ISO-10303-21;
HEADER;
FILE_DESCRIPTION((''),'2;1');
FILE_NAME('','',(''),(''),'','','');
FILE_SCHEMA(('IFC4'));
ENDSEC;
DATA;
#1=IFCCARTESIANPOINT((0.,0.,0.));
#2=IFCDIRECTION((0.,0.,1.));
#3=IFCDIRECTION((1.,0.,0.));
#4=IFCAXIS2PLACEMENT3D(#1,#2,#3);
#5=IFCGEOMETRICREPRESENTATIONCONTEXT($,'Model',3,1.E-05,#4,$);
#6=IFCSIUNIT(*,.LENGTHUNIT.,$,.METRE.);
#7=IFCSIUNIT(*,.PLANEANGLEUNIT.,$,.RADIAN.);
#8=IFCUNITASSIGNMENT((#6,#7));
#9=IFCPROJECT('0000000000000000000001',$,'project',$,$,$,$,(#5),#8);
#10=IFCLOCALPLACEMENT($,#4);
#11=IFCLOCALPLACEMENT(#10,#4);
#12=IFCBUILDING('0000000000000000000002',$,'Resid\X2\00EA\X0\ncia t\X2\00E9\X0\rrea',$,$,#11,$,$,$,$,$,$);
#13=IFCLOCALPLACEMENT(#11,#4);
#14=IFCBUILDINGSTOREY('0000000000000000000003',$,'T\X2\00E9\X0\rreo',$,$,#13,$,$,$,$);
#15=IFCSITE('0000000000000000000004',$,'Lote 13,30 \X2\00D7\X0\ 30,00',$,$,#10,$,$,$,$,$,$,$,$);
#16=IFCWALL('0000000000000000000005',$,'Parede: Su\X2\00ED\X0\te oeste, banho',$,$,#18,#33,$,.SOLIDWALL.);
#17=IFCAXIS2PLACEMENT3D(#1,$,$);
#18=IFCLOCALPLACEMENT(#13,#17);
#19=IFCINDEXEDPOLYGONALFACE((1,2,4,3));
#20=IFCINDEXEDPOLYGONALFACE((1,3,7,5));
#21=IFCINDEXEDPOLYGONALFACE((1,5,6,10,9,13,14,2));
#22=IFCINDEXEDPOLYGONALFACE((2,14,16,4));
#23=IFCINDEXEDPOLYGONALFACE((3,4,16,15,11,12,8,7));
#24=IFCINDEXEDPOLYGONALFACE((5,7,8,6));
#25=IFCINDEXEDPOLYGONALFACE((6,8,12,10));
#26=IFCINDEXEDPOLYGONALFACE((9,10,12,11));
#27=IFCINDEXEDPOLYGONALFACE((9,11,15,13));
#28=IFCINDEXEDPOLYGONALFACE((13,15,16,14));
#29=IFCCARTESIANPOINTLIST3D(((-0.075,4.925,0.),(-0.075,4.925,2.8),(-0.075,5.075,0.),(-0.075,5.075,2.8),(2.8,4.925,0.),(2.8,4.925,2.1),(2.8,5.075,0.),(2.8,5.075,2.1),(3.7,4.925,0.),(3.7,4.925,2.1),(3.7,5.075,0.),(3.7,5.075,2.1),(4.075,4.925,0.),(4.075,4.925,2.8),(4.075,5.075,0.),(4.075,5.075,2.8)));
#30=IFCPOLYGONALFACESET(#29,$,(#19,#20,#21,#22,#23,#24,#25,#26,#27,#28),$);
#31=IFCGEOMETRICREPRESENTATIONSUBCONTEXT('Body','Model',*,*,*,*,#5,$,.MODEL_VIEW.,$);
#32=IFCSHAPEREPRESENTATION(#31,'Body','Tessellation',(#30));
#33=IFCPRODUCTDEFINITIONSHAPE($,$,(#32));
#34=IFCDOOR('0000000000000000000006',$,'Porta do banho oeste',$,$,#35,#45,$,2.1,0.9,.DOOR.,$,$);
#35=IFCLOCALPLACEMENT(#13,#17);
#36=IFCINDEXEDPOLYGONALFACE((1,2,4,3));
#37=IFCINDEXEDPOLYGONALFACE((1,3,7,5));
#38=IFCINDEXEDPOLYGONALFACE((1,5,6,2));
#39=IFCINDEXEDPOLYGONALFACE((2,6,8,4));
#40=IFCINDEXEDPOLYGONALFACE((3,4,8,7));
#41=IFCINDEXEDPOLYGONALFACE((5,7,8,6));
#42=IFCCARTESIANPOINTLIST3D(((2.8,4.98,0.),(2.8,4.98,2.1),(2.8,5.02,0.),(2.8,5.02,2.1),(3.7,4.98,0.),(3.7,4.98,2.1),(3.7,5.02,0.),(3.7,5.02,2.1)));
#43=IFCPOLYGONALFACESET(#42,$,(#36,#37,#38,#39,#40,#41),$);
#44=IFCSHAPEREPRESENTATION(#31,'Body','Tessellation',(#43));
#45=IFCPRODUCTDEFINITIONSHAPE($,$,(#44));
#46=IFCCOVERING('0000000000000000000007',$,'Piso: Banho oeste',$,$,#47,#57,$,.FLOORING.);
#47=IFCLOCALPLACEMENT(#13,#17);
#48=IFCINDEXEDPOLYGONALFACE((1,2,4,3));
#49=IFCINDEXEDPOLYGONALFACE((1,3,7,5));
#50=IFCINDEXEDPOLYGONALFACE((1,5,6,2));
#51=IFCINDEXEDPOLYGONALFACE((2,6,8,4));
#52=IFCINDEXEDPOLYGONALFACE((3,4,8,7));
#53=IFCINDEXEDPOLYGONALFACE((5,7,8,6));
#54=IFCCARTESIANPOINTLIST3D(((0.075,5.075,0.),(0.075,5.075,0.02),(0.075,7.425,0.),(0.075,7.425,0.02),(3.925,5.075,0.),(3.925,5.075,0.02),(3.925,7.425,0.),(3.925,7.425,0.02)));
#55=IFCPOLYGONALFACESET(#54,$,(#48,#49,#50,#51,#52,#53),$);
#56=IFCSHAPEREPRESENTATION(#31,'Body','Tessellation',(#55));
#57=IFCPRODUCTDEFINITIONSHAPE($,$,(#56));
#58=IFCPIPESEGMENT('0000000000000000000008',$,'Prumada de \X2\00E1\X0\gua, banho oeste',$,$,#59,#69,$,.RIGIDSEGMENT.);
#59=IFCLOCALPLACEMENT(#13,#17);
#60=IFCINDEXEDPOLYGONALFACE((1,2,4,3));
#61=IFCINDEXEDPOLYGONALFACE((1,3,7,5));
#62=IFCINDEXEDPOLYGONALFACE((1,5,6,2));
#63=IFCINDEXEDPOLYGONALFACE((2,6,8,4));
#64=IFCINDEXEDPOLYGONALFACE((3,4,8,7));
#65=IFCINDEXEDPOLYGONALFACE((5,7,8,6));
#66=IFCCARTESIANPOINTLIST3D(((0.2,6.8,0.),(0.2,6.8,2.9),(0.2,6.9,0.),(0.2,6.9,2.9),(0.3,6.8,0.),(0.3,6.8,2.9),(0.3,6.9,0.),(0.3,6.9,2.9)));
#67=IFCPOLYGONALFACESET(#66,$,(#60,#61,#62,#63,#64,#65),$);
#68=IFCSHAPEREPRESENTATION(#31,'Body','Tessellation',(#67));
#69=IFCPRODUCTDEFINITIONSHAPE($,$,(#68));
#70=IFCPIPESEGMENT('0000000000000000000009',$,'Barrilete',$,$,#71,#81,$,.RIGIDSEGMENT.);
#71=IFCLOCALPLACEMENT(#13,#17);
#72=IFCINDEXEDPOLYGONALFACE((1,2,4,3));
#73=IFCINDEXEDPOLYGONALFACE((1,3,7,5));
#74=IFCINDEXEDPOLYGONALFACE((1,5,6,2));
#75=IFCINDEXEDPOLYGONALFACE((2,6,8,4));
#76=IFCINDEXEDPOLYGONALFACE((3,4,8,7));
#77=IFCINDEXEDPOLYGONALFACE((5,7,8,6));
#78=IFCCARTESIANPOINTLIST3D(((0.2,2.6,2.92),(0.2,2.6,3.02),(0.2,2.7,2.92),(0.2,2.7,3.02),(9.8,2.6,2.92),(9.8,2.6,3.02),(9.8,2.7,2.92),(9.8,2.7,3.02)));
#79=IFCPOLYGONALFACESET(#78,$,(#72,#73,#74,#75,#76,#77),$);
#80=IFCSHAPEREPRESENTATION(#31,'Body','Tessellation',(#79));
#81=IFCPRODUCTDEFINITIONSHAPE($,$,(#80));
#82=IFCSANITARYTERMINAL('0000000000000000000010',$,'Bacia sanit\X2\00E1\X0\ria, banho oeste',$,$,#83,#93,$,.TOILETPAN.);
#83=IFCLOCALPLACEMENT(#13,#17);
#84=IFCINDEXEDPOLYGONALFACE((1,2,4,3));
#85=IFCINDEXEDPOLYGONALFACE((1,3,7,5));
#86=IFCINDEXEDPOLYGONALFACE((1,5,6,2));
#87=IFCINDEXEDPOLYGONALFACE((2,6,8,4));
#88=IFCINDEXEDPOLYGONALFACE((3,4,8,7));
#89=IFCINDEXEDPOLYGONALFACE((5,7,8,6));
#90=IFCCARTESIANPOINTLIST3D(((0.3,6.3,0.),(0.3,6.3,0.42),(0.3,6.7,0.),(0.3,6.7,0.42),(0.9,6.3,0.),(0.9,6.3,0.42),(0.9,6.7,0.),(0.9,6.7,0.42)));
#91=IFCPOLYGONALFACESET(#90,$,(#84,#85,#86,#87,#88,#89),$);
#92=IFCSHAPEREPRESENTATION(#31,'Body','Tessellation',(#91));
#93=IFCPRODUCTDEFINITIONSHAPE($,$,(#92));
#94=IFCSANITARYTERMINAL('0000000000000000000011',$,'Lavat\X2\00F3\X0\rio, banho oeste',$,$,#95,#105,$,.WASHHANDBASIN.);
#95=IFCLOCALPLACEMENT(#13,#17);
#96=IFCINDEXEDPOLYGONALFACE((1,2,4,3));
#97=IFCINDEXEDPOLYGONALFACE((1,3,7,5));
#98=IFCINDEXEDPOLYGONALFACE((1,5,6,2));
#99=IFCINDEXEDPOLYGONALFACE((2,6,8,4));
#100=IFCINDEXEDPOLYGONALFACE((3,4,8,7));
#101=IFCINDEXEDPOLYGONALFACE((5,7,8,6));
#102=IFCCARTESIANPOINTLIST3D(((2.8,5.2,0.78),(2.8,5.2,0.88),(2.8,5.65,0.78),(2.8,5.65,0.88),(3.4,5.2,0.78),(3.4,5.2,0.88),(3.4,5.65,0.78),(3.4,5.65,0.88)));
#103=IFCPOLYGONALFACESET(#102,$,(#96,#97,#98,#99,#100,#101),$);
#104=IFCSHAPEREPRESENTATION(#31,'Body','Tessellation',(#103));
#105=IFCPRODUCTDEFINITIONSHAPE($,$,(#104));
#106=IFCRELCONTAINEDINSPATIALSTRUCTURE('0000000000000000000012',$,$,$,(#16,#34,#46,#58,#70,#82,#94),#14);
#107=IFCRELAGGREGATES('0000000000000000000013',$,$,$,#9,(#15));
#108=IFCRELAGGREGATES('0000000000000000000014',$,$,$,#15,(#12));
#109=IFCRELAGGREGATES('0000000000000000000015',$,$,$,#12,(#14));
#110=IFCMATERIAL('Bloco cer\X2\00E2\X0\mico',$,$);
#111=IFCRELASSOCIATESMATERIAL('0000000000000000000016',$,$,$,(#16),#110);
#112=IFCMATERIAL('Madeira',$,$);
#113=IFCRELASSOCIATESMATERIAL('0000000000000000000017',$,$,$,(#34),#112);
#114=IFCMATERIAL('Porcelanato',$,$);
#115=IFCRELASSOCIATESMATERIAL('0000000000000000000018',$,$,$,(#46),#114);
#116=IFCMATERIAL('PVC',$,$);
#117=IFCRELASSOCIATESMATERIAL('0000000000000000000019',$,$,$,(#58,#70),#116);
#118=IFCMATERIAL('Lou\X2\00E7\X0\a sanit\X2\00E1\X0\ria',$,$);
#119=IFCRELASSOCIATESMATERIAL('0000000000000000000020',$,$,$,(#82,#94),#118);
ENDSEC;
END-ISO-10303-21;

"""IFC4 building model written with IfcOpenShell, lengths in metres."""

from ifc_helpers import new_model, si_unit, frame, origin_with_axes, place, context, subcontext, project, spatial, line, indexed_curve, outline, extrude, material, element, fill, save


model = new_model("IFC4")

# Units and contexts
model_context = context("Model", 3, precision=1e-05, world=origin_with_axes())
body_context = subcontext(model_context, "Body", "Model", "MODEL_VIEW")
ifc_project = project(units=[si_unit("LENGTHUNIT", "METRE"), si_unit("PLANEANGLEUNIT", "RADIAN")], contexts=[model_context])

# Site, building, storey
site_placement = place(None, origin_with_axes())
site = spatial("IfcSite", under=ifc_project, at=site_placement, Name="Lote 13,30 × 30,00")
building_placement = place(site_placement, origin_with_axes())
building = spatial("IfcBuilding", under=site, at=building_placement, Name="Residência térrea")
storey_placement = place(building_placement, origin_with_axes())
storey = spatial("IfcBuildingStorey", under=building, at=storey_placement, Name="Térreo")

# Shared definitions
ifc_material_1 = material(Name="Concreto armado")

# Shared definitions
ifc_material_2 = material(Name="Bloco cerâmico")

# Wall, opening, door
wall_1_placement = place(storey_placement, frame((-0.075, 4.925, 0.0), z_axis=(0.0, 0.0, 1.0), x_axis=(1.0, 0.0, 0.0)))
wall_1 = element("IfcWall", 1, at=wall_1_placement, inside=storey, material=ifc_material_2, Name="Parede: Suíte oeste, banho", PredefinedType="SOLIDWALL", context=body_context, shape_type="SweptSolid", body=[
    extrude(outline(indexed_curve([(0.0, 0.0), (4.15, 0.0), (4.15, 0.15), (0.0, 0.15)], segments=[line(1, 2, 3, 4, 1)])), origin_with_axes(), (0.0, 0.0, 1.0), 2.8),
])
opening_1_placement = place(wall_1_placement, frame((2.875, -0.05, 0.0), z_axis=(0.0, 0.0, 1.0), x_axis=(1.0, 0.0, 0.0)))
opening_1 = element("IfcOpeningElement", 2, at=opening_1_placement, cuts=wall_1, material=ifc_material_1, PredefinedType="OPENING", context=body_context, shape_type="SweptSolid", body=[
    extrude(outline(indexed_curve([(0.0, 0.0), (0.9, 0.0), (0.9, 0.25), (0.0, 0.25)], segments=[line(1, 2, 3, 4, 1)])), origin_with_axes(), (0.0, 0.0, 1.0), 2.1),
])
ifc_material_3 = material(Name="Madeira")
door_placement = place(storey_placement, frame((2.8, 4.98, 0.0), z_axis=(0.0, 0.0, 1.0), x_axis=(1.0, 0.0, 0.0)))
door = element("IfcDoor", 3, at=door_placement, inside=storey, material=ifc_material_3, Name="Porta do banho oeste", OverallHeight=2.1, OverallWidth=0.9, PredefinedType="DOOR", context=body_context, shape_type="SweptSolid", body=[
    extrude(outline(indexed_curve([(0.0, 0.0), (0.9, 0.0), (0.9, 0.04), (0.0, 0.04)], segments=[line(1, 2, 3, 4, 1)])), origin_with_axes(), (0.0, 0.0, 1.0), 2.1),
])
fill(opening_1, door)

# Covering
ifc_material_4 = material(Name="Porcelanato")
covering_placement = place(storey_placement, frame((0.075, 5.075, 0.0), z_axis=(0.0, 0.0, 1.0), x_axis=(1.0, 0.0, 0.0)))
element("IfcCovering", 4, at=covering_placement, inside=storey, material=ifc_material_4, Name="Piso: Banho oeste", PredefinedType="FLOORING", context=body_context, shape_type="SweptSolid", body=[
    extrude(outline(indexed_curve([(0.0, 0.0), (3.85, 0.0), (3.85, 2.35), (0.0, 2.35)], segments=[line(1, 2, 3, 4, 1)])), origin_with_axes(), (0.0, 0.0, 1.0), 0.02),
])

# Pipe segments
ifc_material_5 = material(Name="PVC")
pipe_segment_1_placement = place(storey_placement, frame((0.2, 6.8, 0.0), z_axis=(0.0, 0.0, 1.0), x_axis=(1.0, 0.0, 0.0)))
element("IfcPipeSegment", 5, at=pipe_segment_1_placement, inside=storey, material=ifc_material_5, Name="Prumada de água, banho oeste", PredefinedType="RIGIDSEGMENT", context=body_context, shape_type="SweptSolid", body=[
    extrude(outline(indexed_curve([(0.0, 0.0), (0.1, 0.0), (0.1, 0.1), (0.0, 0.1)], segments=[line(1, 2, 3, 4, 1)])), origin_with_axes(), (0.0, 0.0, 1.0), 2.9),
])
pipe_segment_2_placement = place(storey_placement, frame((0.2, 2.6, 2.92), z_axis=(0.0, 0.0, 1.0), x_axis=(1.0, 0.0, 0.0)))
element("IfcPipeSegment", 6, at=pipe_segment_2_placement, inside=storey, material=ifc_material_5, Name="Barrilete", PredefinedType="RIGIDSEGMENT", context=body_context, shape_type="SweptSolid", body=[
    extrude(outline(indexed_curve([(0.0, 0.0), (9.6, 0.0), (9.6, 0.1), (0.0, 0.1)], segments=[line(1, 2, 3, 4, 1)])), origin_with_axes(), (0.0, 0.0, 1.0), 0.1),
])

# Sanitary terminals
ifc_material_6 = material(Name="Louça sanitária")
sanitary_terminal_1_placement = place(storey_placement, frame((0.3, 6.3, 0.0), z_axis=(0.0, 0.0, 1.0), x_axis=(1.0, 0.0, 0.0)))
element("IfcSanitaryTerminal", 7, at=sanitary_terminal_1_placement, inside=storey, material=ifc_material_6, Name="Bacia sanitária, banho oeste", PredefinedType="TOILETPAN", context=body_context, shape_type="SweptSolid", body=[
    extrude(outline(indexed_curve([(0.0, 0.0), (0.6, 0.0), (0.6, 0.4), (0.0, 0.4)], segments=[line(1, 2, 3, 4, 1)])), origin_with_axes(), (0.0, 0.0, 1.0), 0.42),
])
sanitary_terminal_2_placement = place(storey_placement, frame((2.8, 5.2, 0.78), z_axis=(0.0, 0.0, 1.0), x_axis=(1.0, 0.0, 0.0)))
element("IfcSanitaryTerminal", 8, at=sanitary_terminal_2_placement, inside=storey, material=ifc_material_6, Name="Lavatório, banho oeste", PredefinedType="WASHHANDBASIN", context=body_context, shape_type="SweptSolid", body=[
    extrude(outline(indexed_curve([(0.0, 0.0), (0.6, 0.0), (0.6, 0.45), (0.0, 0.45)], segments=[line(1, 2, 3, 4, 1)])), origin_with_axes(), (0.0, 0.0, 1.0), 0.1),
])

save(model, "model.ifc")
